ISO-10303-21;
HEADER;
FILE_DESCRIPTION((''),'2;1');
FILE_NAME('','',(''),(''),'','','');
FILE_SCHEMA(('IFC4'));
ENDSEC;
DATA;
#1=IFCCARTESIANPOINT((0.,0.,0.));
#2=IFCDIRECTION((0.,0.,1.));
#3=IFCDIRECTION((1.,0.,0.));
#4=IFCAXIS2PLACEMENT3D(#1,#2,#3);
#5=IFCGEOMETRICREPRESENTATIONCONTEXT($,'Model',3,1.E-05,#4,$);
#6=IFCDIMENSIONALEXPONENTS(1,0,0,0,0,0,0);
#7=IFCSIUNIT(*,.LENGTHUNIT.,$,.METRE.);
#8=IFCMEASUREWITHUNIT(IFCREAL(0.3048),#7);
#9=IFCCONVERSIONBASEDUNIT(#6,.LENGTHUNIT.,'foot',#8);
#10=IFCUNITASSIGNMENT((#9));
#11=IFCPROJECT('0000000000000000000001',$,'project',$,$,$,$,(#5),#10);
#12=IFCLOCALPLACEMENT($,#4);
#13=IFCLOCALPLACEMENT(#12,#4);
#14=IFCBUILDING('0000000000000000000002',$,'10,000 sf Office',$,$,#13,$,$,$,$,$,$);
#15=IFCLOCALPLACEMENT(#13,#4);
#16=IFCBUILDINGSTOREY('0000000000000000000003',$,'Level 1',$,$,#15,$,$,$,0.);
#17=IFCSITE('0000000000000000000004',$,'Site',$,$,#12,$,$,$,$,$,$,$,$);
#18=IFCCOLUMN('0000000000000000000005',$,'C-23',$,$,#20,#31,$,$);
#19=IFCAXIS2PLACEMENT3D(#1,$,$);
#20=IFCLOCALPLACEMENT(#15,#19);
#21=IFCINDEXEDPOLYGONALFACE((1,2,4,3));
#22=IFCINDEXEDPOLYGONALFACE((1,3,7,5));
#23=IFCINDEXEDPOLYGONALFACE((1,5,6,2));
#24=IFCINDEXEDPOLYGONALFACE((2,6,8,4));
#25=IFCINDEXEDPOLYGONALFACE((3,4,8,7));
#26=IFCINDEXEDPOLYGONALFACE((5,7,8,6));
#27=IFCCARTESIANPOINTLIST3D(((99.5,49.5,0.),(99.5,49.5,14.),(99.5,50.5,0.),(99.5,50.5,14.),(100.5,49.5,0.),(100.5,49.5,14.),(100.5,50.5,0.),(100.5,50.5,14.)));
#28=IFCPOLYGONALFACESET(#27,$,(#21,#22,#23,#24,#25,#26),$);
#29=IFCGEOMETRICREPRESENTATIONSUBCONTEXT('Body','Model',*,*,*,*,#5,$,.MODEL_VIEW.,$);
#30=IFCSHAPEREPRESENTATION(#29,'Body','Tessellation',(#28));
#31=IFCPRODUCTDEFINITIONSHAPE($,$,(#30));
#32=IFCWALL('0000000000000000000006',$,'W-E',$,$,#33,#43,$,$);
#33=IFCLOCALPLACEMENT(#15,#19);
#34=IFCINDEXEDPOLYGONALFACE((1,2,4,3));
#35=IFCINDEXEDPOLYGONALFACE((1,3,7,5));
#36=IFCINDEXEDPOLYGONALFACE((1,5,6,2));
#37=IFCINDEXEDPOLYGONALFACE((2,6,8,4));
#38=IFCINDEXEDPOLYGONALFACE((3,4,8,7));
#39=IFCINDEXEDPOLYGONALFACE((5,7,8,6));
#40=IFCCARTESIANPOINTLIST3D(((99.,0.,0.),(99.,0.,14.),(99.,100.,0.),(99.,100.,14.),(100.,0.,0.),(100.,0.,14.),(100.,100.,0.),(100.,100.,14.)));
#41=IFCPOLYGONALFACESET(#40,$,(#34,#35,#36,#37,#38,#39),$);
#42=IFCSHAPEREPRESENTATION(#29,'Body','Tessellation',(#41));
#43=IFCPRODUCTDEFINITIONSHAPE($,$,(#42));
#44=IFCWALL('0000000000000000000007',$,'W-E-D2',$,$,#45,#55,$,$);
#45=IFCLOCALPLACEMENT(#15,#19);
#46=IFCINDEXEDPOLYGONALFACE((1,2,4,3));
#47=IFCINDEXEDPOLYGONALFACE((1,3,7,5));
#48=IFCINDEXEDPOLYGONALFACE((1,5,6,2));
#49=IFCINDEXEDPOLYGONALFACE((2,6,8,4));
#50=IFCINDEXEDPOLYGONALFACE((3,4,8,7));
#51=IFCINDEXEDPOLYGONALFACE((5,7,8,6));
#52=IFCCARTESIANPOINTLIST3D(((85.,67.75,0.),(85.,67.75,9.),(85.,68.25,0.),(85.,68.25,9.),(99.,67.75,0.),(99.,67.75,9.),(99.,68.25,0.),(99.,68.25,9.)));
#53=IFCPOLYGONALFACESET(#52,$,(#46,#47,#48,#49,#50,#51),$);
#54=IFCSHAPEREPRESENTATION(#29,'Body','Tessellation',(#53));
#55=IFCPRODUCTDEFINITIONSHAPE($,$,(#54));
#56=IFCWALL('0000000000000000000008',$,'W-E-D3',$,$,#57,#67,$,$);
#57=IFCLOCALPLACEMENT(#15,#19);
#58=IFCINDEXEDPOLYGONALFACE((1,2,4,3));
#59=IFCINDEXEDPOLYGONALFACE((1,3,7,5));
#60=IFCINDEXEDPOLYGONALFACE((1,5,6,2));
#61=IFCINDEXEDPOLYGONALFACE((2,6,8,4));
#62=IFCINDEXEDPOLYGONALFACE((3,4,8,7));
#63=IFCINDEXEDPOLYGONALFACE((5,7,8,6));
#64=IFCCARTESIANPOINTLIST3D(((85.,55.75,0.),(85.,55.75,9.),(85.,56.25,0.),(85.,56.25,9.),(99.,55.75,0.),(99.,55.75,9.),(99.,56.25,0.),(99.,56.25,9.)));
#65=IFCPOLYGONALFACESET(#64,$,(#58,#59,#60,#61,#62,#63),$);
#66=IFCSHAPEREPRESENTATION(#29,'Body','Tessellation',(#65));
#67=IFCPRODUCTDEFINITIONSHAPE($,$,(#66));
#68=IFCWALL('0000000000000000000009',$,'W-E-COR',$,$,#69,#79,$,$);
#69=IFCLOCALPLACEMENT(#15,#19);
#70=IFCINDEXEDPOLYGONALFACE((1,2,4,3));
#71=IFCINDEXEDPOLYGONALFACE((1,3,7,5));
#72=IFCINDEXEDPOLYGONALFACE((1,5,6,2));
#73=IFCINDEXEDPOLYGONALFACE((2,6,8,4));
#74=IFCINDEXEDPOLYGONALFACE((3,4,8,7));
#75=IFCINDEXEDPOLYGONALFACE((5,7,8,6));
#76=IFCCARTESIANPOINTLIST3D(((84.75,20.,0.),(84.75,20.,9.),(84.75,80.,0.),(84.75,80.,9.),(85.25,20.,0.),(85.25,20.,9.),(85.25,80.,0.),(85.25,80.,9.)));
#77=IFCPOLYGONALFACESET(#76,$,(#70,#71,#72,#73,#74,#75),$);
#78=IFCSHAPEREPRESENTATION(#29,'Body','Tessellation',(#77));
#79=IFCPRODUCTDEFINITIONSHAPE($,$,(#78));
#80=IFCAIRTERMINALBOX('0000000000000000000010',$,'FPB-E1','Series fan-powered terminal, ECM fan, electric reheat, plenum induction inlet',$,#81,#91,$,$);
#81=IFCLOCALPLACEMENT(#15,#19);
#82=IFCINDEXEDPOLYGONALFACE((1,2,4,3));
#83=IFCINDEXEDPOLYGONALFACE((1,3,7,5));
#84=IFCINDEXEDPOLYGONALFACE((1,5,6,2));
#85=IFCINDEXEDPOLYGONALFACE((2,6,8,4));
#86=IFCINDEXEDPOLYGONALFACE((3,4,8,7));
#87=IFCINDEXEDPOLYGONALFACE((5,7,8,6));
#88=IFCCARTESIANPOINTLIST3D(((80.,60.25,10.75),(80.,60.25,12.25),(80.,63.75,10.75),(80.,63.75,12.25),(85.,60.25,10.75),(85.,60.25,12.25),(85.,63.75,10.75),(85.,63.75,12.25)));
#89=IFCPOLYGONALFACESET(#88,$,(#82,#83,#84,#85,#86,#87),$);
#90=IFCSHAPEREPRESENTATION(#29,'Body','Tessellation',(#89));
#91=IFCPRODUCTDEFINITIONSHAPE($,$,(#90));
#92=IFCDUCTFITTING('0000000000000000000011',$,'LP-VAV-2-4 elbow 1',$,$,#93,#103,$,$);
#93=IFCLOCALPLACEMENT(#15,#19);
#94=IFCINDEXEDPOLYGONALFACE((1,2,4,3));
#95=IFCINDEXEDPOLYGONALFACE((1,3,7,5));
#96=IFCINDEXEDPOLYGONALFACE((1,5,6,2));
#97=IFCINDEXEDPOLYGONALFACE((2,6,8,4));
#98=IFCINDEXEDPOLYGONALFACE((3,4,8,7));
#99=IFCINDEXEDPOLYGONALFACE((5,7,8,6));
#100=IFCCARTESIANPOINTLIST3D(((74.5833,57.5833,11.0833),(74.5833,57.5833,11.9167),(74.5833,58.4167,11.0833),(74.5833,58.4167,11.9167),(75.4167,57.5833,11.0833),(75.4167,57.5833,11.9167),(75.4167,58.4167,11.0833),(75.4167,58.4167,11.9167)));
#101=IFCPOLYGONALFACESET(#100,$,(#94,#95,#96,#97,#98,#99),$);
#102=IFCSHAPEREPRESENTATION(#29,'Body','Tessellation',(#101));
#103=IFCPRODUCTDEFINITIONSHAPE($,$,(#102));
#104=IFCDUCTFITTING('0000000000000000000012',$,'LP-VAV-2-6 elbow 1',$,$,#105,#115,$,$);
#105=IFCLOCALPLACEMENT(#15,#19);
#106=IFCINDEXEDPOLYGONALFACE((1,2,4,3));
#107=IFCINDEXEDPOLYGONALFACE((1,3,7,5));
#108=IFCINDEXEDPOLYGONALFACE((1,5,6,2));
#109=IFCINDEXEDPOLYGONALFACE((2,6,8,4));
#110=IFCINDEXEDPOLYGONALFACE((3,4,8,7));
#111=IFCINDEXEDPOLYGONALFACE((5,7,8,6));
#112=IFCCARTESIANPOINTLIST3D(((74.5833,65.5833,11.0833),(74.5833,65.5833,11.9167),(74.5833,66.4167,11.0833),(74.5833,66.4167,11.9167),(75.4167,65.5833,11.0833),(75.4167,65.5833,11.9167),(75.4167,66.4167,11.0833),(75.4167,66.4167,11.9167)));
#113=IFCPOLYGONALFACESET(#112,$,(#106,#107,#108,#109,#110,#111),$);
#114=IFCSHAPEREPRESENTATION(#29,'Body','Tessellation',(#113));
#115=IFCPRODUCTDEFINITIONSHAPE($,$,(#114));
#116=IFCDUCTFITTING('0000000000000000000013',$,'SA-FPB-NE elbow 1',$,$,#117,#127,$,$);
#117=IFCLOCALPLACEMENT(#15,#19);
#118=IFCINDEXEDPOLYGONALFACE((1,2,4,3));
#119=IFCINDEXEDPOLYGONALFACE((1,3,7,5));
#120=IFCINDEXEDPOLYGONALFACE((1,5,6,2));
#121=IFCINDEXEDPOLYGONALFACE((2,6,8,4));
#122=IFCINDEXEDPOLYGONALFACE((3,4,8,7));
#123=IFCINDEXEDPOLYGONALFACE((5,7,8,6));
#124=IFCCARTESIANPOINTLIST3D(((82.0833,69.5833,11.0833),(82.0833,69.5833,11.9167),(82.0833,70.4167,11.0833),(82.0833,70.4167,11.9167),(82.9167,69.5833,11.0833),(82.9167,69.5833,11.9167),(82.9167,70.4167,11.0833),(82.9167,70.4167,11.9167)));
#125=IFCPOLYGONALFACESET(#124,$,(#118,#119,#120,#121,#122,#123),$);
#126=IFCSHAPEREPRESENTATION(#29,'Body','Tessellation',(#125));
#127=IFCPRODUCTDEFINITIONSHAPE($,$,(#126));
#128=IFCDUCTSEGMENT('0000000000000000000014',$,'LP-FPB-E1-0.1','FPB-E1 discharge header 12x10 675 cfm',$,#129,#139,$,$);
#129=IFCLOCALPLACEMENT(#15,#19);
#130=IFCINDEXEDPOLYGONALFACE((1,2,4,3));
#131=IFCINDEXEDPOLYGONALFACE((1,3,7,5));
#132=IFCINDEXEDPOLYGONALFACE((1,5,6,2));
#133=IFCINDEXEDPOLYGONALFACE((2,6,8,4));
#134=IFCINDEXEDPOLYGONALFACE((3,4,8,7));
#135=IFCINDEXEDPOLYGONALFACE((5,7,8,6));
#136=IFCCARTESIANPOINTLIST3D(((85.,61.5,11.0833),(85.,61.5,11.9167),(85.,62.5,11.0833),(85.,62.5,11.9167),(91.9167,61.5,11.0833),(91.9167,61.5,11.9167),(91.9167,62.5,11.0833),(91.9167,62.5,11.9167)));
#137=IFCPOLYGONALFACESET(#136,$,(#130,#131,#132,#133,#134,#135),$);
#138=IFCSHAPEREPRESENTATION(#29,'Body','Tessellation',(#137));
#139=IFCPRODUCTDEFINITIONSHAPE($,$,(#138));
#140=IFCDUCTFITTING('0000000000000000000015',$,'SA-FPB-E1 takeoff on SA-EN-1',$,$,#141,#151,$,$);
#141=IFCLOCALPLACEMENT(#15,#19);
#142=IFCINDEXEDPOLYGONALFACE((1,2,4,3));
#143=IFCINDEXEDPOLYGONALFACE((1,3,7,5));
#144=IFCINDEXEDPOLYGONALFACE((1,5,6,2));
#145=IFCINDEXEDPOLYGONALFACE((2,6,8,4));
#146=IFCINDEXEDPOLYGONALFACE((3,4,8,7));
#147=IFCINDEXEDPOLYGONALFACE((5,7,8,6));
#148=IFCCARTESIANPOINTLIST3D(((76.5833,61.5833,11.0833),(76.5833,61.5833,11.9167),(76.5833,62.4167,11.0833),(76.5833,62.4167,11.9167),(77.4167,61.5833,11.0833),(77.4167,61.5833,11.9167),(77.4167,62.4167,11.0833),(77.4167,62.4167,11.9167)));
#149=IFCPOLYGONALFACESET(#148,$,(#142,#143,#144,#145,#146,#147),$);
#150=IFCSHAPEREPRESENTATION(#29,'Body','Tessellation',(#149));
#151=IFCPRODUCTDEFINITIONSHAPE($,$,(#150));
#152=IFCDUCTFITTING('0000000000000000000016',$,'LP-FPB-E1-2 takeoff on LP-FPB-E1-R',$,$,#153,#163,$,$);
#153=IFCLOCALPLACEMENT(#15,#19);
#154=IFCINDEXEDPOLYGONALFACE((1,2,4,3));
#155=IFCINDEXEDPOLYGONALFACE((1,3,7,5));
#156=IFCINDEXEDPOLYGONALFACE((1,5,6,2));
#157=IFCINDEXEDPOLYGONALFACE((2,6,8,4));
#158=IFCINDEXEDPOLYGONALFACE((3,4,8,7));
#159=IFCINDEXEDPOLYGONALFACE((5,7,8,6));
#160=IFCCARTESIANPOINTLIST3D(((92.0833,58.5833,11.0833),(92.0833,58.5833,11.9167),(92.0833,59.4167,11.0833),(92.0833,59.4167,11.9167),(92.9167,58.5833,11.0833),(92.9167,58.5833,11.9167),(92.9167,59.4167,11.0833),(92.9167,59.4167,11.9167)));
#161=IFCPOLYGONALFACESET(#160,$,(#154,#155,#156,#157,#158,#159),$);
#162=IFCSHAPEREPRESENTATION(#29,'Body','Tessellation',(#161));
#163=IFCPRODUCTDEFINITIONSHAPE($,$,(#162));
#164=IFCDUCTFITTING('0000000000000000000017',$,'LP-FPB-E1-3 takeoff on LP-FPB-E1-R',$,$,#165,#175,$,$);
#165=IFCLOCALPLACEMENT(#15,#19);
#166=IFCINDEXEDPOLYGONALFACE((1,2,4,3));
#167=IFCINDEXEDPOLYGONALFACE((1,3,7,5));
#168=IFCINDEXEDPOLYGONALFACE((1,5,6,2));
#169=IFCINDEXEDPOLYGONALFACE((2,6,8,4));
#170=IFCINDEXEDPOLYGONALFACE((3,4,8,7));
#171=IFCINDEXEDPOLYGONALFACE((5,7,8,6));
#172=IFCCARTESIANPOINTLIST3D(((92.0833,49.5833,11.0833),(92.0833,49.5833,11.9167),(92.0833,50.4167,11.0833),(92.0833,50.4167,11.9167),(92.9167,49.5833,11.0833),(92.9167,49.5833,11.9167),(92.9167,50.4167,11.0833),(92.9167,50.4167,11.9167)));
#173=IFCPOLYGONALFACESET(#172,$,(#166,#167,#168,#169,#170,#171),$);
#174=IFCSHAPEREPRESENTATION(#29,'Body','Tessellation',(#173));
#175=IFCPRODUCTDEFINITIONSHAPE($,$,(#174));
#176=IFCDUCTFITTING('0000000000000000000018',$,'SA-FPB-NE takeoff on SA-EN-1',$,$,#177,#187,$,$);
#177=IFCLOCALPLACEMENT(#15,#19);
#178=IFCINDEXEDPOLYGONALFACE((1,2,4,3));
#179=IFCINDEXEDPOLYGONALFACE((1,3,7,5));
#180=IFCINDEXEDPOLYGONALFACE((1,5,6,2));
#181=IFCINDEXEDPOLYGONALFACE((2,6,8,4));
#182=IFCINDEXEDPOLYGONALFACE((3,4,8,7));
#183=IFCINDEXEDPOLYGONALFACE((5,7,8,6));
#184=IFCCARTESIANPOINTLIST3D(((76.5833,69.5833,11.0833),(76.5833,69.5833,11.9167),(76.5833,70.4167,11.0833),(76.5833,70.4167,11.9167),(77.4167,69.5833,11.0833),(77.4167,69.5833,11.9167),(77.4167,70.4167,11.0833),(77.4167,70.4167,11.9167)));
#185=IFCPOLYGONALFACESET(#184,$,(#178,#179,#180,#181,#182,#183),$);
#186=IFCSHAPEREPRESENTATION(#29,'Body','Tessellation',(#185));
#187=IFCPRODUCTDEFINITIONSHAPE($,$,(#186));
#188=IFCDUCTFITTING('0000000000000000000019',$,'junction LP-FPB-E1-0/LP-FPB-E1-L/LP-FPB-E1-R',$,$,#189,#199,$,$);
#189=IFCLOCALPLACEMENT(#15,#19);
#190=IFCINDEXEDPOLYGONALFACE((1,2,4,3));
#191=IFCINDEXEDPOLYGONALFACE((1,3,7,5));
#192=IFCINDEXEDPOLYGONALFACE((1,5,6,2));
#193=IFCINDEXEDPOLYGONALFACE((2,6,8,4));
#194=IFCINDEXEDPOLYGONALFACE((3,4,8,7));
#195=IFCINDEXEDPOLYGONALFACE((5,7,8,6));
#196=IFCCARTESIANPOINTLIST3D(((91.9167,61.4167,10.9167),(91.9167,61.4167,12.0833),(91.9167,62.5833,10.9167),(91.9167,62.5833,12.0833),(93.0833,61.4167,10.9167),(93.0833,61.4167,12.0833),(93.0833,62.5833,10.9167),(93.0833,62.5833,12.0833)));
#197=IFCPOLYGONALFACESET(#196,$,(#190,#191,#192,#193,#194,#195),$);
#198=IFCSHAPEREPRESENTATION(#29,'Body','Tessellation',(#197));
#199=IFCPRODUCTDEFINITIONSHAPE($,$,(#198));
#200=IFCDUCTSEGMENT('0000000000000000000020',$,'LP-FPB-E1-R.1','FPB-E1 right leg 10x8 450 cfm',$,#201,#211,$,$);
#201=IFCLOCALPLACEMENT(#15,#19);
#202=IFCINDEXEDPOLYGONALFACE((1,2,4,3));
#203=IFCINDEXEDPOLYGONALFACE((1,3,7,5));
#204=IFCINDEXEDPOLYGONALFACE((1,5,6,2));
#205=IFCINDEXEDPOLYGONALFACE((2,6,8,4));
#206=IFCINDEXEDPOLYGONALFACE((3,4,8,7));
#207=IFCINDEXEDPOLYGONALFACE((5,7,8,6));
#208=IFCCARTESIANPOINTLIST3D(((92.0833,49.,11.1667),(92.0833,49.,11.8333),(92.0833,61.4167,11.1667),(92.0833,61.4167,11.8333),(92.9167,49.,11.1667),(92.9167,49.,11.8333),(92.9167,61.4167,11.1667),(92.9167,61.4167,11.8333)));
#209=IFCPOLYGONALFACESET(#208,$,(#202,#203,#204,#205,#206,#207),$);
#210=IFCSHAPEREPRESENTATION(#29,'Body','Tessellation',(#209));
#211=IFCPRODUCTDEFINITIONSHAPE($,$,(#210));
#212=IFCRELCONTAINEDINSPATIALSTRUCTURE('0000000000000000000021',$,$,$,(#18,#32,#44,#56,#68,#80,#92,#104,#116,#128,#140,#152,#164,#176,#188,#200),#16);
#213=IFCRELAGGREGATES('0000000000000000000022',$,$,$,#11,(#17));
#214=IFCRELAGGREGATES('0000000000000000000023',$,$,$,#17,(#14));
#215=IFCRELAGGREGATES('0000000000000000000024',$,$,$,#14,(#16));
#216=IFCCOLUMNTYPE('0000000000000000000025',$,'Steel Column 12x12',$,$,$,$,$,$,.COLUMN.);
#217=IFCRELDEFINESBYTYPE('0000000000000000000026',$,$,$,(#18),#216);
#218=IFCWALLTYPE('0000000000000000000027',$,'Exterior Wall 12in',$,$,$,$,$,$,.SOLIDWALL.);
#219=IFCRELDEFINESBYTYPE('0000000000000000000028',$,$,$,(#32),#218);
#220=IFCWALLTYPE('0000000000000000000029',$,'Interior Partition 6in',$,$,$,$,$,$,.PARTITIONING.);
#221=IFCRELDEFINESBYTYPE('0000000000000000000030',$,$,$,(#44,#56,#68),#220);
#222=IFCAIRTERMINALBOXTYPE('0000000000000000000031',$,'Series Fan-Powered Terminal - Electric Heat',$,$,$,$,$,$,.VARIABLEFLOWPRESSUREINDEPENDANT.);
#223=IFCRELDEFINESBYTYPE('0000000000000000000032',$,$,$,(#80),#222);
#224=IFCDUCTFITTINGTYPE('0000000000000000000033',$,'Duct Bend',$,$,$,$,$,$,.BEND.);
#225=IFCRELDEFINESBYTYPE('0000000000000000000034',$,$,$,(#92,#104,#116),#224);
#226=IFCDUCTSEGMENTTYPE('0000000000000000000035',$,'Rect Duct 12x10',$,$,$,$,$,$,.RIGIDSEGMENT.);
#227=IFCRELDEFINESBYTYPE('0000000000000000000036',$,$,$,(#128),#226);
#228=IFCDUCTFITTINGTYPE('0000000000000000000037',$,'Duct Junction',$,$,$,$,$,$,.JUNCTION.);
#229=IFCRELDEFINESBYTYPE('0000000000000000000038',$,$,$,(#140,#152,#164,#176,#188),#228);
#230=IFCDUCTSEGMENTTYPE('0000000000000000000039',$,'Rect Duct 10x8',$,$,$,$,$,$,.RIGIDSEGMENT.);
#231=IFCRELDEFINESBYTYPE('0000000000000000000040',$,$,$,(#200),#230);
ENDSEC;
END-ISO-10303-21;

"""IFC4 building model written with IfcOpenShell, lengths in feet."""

from ifc_helpers import new_model, entity, si_unit, converted_unit, frame, origin_with_axes, place, context, subcontext, project, spatial, rectangle, extrude, type_object, element, save


model = new_model("IFC4")

# Units and contexts
model_context = context("Model", 3, precision=1e-05, world=origin_with_axes())
body_context = subcontext(model_context, "Body", "Model", "MODEL_VIEW")
ifc_project = project(units=[converted_unit("LENGTHUNIT", "foot", entity("IfcReal", 0.3048), si_unit("LENGTHUNIT", "METRE"), dimensions=[1, 0, 0, 0, 0, 0, 0])], contexts=[model_context])

# Site, building, storey
site_placement = place(None, origin_with_axes())
site = spatial("IfcSite", under=ifc_project, at=site_placement, Name="Site")
building_placement = place(site_placement, origin_with_axes())
building = spatial("IfcBuilding", under=site, at=building_placement, Name="10,000 sf Office")
storey_placement = place(building_placement, origin_with_axes())
storey = spatial("IfcBuildingStorey", under=building, at=storey_placement, Name="Level 1", Elevation=0.0)

# Column
column_type = type_object("IfcColumnType", Name="Steel Column 12x12", PredefinedType="COLUMN")
column_placement = place(storey_placement, frame((100.0, 50.0, 0.0), z_axis=(0.0, 0.0, 1.0), x_axis=(1.0, 0.0, 0.0)))
element("IfcColumn", 1, at=column_placement, inside=storey, type_object=column_type, Name="C-23", context=body_context, shape_type="SweptSolid", body=[
    extrude(rectangle(XDim=1.0, YDim=1.0), None, (0.0, 0.0, 1.0), 14.0),
])

# Walls
wall_type_1 = type_object("IfcWallType", Name="Exterior Wall 12in", PredefinedType="SOLIDWALL")
wall_1_placement = place(storey_placement, frame((99.5, 50.0, 0.0), z_axis=(0.0, 0.0, 1.0), x_axis=(0.0, 1.0, 0.0)))
element("IfcWall", 2, at=wall_1_placement, inside=storey, type_object=wall_type_1, Name="W-E", context=body_context, shape_type="SweptSolid", body=[
    extrude(rectangle(XDim=100.0, YDim=1.0), None, (0.0, 0.0, 1.0), 14.0),
])
wall_type_2 = type_object("IfcWallType", Name="Interior Partition 6in", PredefinedType="PARTITIONING")
for number, where, z_axis, x_axis, name in (
    (3, (92.0, 68.0, 0.0), (0.0, 0.0, 1.0), (-1.0, 0.0, 0.0), "W-E-D2"),
    (4, (92.0, 56.0, 0.0), (0.0, 0.0, 1.0), (-1.0, 0.0, 0.0), "W-E-D3"),
):
    element("IfcWall", number, at=place(storey_placement, frame(where, z_axis=z_axis, x_axis=x_axis)), inside=storey, type_object=wall_type_2, Name=name, context=body_context, shape_type="SweptSolid", body=[
        extrude(rectangle(XDim=14.0, YDim=0.5), None, (0.0, 0.0, 1.0), 9.0),
    ])
wall_2_placement = place(storey_placement, frame((85.0, 50.0, 0.0), z_axis=(0.0, 0.0, 1.0), x_axis=(0.0, -1.0, 0.0)))
element("IfcWall", 5, at=wall_2_placement, inside=storey, type_object=wall_type_2, Name="W-E-COR", context=body_context, shape_type="SweptSolid", body=[
    extrude(rectangle(XDim=60.0, YDim=0.5), None, (0.0, 0.0, 1.0), 9.0),
])

# Air terminal box
air_terminal_box_type = type_object("IfcAirTerminalBoxType", Name="Series Fan-Powered Terminal - Electric Heat", PredefinedType="VARIABLEFLOWPRESSUREINDEPENDANT")
air_terminal_box_placement = place(storey_placement, frame((82.5, 62.0, 10.75), z_axis=(0.0, 0.0, 1.0), x_axis=(1.0, 0.0, 0.0)))
element("IfcAirTerminalBox", 6, at=air_terminal_box_placement, inside=storey, type_object=air_terminal_box_type, Name="FPB-E1", Description="Series fan-powered terminal, ECM fan, electric reheat, plenum induction inlet", context=body_context, shape_type="SweptSolid", body=[
    extrude(rectangle(XDim=5.0, YDim=3.5), None, (0.0, 0.0, 1.0), 1.5),
])

# Duct fittings
duct_fitting_type_1 = type_object("IfcDuctFittingType", Name="Duct Bend", PredefinedType="BEND")
for number, where, z_axis, x_axis, name in (
    (7, (75.0, 58.0, 11.0833), (0.0, 0.0, 1.0), (1.0, 0.0, 0.0), "LP-VAV-2-4 elbow 1"),
    (8, (75.0, 66.0, 11.0833), (0.0, 0.0, 1.0), (1.0, 0.0, 0.0), "LP-VAV-2-6 elbow 1"),
    (9, (82.5, 70.0, 11.0833), (0.0, 0.0, 1.0), (1.0, 0.0, 0.0), "SA-FPB-NE elbow 1"),
):
    element("IfcDuctFitting", number, at=place(storey_placement, frame(where, z_axis=z_axis, x_axis=x_axis)), inside=storey, type_object=duct_fitting_type_1, Name=name, context=body_context, shape_type="SweptSolid", body=[
        extrude(rectangle(XDim=0.8333, YDim=0.8333), None, (0.0, 0.0, 1.0), 0.8333),
    ])

# Duct segment
duct_segment_type_1 = type_object("IfcDuctSegmentType", Name="Rect Duct 12x10", PredefinedType="RIGIDSEGMENT")
duct_segment_1_placement = place(storey_placement, frame((85.0, 62.0, 11.5), z_axis=(1.0, 0.0, 0.0), x_axis=(0.0, 1.0, 0.0)))
element("IfcDuctSegment", 10, at=duct_segment_1_placement, inside=storey, type_object=duct_segment_type_1, Name="LP-FPB-E1-0.1", Description="FPB-E1 discharge header 12x10 675 cfm", context=body_context, shape_type="SweptSolid", body=[
    extrude(rectangle(XDim=1.0, YDim=0.8333), None, (0.0, 0.0, 1.0), 6.9167),
])

# Duct fittings
duct_fitting_type_2 = type_object("IfcDuctFittingType", Name="Duct Junction", PredefinedType="JUNCTION")
for number, where, z_axis, x_axis, name in (
    (11, (77.0, 62.0, 11.0833), (0.0, 0.0, 1.0), (1.0, 0.0, 0.0), "SA-FPB-E1 takeoff on SA-EN-1"),
    (12, (92.5, 59.0, 11.0833), (0.0, 0.0, 1.0), (1.0, 0.0, 0.0), "LP-FPB-E1-2 takeoff on LP-FPB-E1-R"),
    (13, (92.5, 50.0, 11.0833), (0.0, 0.0, 1.0), (1.0, 0.0, 0.0), "LP-FPB-E1-3 takeoff on LP-FPB-E1-R"),
    (14, (77.0, 70.0, 11.0833), (0.0, 0.0, 1.0), (1.0, 0.0, 0.0), "SA-FPB-NE takeoff on SA-EN-1"),
):
    element("IfcDuctFitting", number, at=place(storey_placement, frame(where, z_axis=z_axis, x_axis=x_axis)), inside=storey, type_object=duct_fitting_type_2, Name=name, context=body_context, shape_type="SweptSolid", body=[
        extrude(rectangle(XDim=0.8333, YDim=0.8333), None, (0.0, 0.0, 1.0), 0.8333),
    ])
duct_fitting_placement = place(storey_placement, frame((92.5, 62.0, 10.9167), z_axis=(0.0, 0.0, 1.0), x_axis=(1.0, 0.0, 0.0)))
element("IfcDuctFitting", 15, at=duct_fitting_placement, inside=storey, type_object=duct_fitting_type_2, Name="junction LP-FPB-E1-0/LP-FPB-E1-L/LP-FPB-E1-R", context=body_context, shape_type="SweptSolid", body=[
    extrude(rectangle(XDim=1.1667, YDim=1.1667), None, (0.0, 0.0, 1.0), 1.1667),
])

# Duct segment
duct_segment_type_2 = type_object("IfcDuctSegmentType", Name="Rect Duct 10x8", PredefinedType="RIGIDSEGMENT")
duct_segment_2_placement = place(storey_placement, frame((92.5, 61.4167, 11.5), z_axis=(0.0, -1.0, 0.0), x_axis=(1.0, 0.0, 0.0)))
element("IfcDuctSegment", 16, at=duct_segment_2_placement, inside=storey, type_object=duct_segment_type_2, Name="LP-FPB-E1-R.1", Description="FPB-E1 right leg 10x8 450 cfm", context=body_context, shape_type="SweptSolid", body=[
    extrude(rectangle(XDim=0.8333, YDim=0.6667), None, (0.0, 0.0, 1.0), 12.4167),
])

save(model, "model.ifc")
